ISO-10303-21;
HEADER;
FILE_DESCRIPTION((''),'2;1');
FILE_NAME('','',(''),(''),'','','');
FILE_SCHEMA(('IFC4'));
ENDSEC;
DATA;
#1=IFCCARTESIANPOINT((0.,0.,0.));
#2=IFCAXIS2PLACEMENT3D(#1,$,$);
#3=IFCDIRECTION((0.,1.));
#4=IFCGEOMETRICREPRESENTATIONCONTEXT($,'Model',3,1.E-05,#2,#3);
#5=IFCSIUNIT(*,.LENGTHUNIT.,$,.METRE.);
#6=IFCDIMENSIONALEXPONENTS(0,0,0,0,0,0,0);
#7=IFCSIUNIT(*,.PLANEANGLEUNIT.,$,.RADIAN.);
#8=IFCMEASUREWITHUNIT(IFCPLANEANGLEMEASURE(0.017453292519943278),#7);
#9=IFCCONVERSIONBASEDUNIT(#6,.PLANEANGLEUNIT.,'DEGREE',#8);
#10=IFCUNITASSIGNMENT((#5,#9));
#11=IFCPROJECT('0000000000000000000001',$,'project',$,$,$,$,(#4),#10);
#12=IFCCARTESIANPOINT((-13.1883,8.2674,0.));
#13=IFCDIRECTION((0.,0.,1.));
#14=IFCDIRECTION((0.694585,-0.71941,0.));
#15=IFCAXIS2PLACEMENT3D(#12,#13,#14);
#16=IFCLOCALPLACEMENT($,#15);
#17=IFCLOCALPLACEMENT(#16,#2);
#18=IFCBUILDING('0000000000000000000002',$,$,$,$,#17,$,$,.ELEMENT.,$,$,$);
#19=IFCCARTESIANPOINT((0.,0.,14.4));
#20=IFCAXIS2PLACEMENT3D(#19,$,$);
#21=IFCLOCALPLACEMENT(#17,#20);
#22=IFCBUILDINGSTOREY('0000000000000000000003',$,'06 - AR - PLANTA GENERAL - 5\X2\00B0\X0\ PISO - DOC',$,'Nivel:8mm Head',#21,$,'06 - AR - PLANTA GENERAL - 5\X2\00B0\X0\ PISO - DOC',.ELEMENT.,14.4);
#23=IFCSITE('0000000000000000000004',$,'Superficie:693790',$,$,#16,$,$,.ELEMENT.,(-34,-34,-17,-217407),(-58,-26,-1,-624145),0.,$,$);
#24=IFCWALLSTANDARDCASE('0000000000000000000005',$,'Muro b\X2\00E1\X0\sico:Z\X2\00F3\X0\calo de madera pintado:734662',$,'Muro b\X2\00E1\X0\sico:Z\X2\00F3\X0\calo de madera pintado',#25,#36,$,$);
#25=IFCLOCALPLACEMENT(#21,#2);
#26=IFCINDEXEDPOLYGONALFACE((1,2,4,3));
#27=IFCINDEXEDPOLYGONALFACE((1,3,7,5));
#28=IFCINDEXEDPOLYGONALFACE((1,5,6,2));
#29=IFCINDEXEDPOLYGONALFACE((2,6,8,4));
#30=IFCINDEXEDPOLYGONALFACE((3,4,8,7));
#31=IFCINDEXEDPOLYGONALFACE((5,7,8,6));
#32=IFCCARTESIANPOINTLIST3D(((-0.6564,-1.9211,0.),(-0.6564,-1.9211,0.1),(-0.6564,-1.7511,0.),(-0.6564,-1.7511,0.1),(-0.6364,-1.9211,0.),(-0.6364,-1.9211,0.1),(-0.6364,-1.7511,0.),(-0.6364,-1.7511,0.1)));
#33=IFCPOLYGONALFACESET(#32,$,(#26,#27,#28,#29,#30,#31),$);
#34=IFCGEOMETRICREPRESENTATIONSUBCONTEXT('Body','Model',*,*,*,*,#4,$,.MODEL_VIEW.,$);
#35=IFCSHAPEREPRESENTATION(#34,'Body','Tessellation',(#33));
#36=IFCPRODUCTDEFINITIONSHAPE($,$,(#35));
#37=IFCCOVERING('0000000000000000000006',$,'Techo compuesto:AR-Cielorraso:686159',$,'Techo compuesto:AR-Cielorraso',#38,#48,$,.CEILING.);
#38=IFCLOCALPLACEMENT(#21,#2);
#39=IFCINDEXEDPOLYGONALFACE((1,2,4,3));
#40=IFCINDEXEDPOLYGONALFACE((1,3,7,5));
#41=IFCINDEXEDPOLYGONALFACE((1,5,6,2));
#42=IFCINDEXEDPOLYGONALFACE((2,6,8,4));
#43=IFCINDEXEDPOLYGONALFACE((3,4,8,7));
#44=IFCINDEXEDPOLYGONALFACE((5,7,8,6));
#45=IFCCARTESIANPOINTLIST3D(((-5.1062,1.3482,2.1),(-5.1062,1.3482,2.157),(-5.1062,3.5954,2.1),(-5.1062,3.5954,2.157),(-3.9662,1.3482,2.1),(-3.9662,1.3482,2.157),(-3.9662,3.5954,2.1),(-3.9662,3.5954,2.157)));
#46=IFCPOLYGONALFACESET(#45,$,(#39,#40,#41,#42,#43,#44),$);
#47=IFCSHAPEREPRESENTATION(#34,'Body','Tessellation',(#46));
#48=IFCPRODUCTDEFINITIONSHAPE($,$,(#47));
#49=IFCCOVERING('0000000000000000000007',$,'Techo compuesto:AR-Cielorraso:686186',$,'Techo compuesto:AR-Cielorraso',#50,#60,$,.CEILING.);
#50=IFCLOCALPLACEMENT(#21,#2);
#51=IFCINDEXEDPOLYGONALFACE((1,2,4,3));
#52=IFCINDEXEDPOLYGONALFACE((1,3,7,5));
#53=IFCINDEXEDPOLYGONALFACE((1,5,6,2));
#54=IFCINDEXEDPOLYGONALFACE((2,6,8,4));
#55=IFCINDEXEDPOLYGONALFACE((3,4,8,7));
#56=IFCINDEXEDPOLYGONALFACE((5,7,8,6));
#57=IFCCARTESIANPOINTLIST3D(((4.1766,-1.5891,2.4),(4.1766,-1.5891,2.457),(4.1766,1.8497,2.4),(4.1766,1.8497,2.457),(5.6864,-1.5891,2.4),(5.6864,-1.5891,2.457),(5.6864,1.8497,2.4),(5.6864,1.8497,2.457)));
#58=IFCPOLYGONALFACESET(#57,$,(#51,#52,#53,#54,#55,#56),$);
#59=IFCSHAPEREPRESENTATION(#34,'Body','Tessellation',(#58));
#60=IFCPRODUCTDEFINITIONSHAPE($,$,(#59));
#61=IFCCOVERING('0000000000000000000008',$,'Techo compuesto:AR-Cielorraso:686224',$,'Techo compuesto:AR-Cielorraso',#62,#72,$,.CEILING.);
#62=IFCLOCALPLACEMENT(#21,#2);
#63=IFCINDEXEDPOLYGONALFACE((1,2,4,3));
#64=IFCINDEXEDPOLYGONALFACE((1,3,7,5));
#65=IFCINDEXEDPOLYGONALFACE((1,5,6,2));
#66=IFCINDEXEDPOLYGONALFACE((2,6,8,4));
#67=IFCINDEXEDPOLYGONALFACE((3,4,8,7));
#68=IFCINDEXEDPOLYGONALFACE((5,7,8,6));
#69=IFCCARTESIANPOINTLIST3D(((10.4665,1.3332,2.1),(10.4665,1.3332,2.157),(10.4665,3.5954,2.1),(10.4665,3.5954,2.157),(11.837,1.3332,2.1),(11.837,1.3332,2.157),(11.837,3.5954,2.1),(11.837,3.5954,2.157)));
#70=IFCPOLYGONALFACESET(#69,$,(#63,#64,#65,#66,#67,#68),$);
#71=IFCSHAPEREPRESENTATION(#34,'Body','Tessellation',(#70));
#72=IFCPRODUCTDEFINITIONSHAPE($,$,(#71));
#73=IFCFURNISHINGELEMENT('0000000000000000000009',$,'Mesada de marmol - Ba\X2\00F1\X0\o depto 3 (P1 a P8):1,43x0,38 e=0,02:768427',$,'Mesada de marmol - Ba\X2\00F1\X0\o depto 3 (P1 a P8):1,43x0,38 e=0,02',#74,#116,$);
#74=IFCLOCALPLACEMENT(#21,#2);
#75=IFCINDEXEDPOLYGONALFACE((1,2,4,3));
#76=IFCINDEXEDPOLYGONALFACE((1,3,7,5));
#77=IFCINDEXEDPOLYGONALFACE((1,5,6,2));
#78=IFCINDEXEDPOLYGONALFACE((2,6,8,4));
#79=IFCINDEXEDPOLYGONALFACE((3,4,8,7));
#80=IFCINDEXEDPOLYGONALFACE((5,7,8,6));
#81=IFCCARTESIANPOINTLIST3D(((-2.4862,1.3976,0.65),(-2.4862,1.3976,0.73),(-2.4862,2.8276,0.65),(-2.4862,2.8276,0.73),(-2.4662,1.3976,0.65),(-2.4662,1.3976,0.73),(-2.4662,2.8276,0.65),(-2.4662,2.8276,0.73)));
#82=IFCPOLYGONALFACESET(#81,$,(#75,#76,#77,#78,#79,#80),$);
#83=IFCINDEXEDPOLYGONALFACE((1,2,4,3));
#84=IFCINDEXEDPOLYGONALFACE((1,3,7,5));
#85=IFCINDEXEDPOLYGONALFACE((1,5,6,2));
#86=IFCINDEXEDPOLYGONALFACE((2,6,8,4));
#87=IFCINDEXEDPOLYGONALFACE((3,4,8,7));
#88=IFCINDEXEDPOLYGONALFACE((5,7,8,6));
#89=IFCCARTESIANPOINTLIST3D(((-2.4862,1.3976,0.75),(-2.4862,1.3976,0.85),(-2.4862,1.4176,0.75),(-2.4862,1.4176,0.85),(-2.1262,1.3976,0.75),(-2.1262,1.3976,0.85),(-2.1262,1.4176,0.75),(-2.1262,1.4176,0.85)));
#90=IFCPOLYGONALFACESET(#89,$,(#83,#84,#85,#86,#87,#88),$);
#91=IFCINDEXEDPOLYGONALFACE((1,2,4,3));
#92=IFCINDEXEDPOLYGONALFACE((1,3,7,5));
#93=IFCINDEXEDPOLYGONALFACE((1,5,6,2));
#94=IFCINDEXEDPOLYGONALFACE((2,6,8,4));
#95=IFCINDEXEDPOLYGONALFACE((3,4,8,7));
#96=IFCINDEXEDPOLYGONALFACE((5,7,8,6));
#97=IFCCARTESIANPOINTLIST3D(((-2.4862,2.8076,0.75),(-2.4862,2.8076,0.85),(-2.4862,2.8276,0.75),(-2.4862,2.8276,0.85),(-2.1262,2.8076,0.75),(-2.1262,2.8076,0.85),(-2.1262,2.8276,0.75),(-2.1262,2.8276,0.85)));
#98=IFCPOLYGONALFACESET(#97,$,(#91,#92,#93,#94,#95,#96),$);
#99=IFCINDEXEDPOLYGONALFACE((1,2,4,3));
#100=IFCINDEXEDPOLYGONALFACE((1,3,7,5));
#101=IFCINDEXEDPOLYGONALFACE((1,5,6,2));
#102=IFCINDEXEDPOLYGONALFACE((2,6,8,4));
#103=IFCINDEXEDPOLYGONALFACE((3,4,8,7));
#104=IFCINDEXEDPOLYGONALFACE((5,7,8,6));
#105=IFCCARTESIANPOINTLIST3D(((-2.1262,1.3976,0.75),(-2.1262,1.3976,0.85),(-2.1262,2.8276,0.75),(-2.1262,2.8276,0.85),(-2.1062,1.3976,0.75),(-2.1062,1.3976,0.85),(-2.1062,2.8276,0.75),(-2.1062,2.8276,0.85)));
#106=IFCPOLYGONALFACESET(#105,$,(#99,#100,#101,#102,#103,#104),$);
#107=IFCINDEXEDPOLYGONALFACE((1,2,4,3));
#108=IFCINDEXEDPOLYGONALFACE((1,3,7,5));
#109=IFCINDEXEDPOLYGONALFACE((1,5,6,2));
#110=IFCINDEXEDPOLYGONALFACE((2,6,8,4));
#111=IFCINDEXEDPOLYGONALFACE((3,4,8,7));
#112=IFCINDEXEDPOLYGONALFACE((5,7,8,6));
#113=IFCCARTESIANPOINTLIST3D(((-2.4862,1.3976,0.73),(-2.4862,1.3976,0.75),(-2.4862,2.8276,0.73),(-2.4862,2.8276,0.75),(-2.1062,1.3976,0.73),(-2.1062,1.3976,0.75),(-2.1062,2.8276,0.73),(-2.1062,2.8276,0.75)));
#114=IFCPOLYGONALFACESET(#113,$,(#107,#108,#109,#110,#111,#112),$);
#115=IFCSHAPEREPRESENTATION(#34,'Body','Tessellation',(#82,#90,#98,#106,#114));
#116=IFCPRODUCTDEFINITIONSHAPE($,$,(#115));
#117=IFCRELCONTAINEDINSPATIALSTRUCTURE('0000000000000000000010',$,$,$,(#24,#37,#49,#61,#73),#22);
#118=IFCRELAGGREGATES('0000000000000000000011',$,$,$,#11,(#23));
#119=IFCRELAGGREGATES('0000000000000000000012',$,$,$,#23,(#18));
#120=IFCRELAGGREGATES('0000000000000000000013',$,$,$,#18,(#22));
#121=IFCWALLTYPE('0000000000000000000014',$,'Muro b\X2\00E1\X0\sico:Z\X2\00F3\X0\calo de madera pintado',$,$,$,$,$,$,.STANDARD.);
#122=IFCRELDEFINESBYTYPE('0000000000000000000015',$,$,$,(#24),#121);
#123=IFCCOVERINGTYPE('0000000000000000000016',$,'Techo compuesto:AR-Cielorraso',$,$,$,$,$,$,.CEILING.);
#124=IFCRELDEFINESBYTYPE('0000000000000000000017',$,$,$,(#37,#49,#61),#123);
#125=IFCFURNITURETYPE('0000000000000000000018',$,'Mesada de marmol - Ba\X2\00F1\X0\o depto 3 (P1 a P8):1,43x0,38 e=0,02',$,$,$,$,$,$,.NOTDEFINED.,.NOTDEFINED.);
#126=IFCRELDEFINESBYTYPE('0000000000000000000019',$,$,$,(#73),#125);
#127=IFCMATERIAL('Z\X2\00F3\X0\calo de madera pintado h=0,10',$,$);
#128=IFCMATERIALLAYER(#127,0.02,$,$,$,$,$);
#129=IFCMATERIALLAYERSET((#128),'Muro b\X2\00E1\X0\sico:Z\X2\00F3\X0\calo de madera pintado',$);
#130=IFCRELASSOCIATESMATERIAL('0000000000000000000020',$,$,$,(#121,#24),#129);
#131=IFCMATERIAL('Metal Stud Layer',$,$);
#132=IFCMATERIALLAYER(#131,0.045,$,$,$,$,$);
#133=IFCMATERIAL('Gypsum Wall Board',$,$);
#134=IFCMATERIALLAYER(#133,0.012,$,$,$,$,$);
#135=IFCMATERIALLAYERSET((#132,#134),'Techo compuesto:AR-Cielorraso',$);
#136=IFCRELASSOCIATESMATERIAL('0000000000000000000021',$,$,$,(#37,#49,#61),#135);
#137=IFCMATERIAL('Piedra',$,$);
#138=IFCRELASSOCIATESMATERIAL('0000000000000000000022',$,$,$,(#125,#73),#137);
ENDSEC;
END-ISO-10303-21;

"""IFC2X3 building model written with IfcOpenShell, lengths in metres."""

from ifc_helpers import new_model, entity, si_unit, converted_unit, direction, frame, frame_2d, origin, origin_2d_with_axis, place, context, subcontext, project, spatial, rectangle, extrude, source, transform, mapped, material, layer, layer_set, layer_usage, type_object, type_shapes, element, save


model = new_model("IFC2X3")

# Units and contexts
model_context = context("Model", 3, precision=1e-05, world=origin(), true_north=direction((0.0, 1.0)))
body_context = subcontext(model_context, "Body", "Model", "MODEL_VIEW")
ifc_project = project(units=[si_unit("LENGTHUNIT", "METRE"), converted_unit("PLANEANGLEUNIT", "DEGREE", entity("IfcPlaneAngleMeasure", 0.017453292519943278), si_unit("PLANEANGLEUNIT", "RADIAN"), dimensions=[0, 0, 0, 0, 0, 0, 0])], contexts=[model_context])

# Site, building, storey
site_placement = place(None, frame((-13.1883, 8.2674, 0.0), z_axis=(0.0, 0.0, 1.0), x_axis=(0.694585, -0.71941, 0.0)))
site = spatial("IfcSite", under=ifc_project, at=site_placement, Name="Superficie:693790", CompositionType="ELEMENT", RefLatitude=(-34, -34, -17, -217407), RefLongitude=(-58, -26, -1, -624145), RefElevation=0.0)
building_placement = place(site_placement, origin())
building = spatial("IfcBuilding", under=site, at=building_placement, CompositionType="ELEMENT")
storey_placement = place(building_placement, frame((0.0, 0.0, 14.4)))
storey = spatial("IfcBuildingStorey", under=building, at=storey_placement, Name="06 - AR - PLANTA GENERAL - 5° PISO - DOC", ObjectType="Nivel:8mm Head", LongName="06 - AR - PLANTA GENERAL - 5° PISO - DOC", CompositionType="ELEMENT", Elevation=14.4)

# Wall
ifc_material_1 = material(Name="Zócalo de madera pintado h=0,10")
ifc_layer_1 = layer(ifc_material_1, 0.02)
ifc_layer_set_1 = layer_set([ifc_layer_1], Name="Muro básico:Zócalo de madera pintado")
wall_type_1 = type_object("IfcWallType", Name="Muro básico:Zócalo de madera pintado", PredefinedType="STANDARD", material=ifc_layer_set_1)
ifc_layer_usage_1 = layer_usage(ifc_layer_set_1, "AXIS2", "NEGATIVE", 0.01)
wall_1_placement = place(storey_placement, frame((-0.6464, -1.7511, 0.0), z_axis=(0.0, 0.0, 1.0), x_axis=(0.0, -1.0, 0.0)))
element("IfcWallStandardCase", 1, at=wall_1_placement, inside=storey, type_object=wall_type_1, material=ifc_layer_usage_1, Name="Muro básico:Zócalo de madera pintado:734662", ObjectType="Muro básico:Zócalo de madera pintado", context=body_context, shape_type="SweptSolid", body=[
    extrude(rectangle(XDim=0.17, YDim=0.02, at=frame_2d((0.085, 0.0), x_axis=(-1.0, 0.0))), origin(), (0.0, 0.0, 1.0), 0.1),
])

# Coverings
ifc_material_2 = material(Name="Metal Stud Layer")
ifc_layer_2 = layer(ifc_material_2, 0.045)
ifc_material_3 = material(Name="Gypsum Wall Board")
ifc_layer_3 = layer(ifc_material_3, 0.012)
ifc_layer_set_2 = layer_set([ifc_layer_2, ifc_layer_3], Name="Techo compuesto:AR-Cielorraso")
covering_type = type_object("IfcCoveringType", Name="Techo compuesto:AR-Cielorraso", PredefinedType="CEILING")
ifc_layer_usage_2 = layer_usage(ifc_layer_set_2, "AXIS3", "NEGATIVE", 0.057)
covering_1_placement = place(storey_placement, origin())
element("IfcCovering", 2, at=covering_1_placement, inside=storey, type_object=covering_type, material=ifc_layer_usage_2, Name="Techo compuesto:AR-Cielorraso:686159", ObjectType="Techo compuesto:AR-Cielorraso", PredefinedType="CEILING", context=body_context, shape_type="SweptSolid", body=[
    extrude(rectangle(XDim=1.14, YDim=2.2473, at=frame_2d((0.0, 0.0), x_axis=(1.0, 0.0))), frame((-4.5362, 2.4718, 2.1), z_axis=(0.0, 0.0, 1.0), x_axis=(-1.0, 0.0, 0.0)), (0.0, 0.0, 1.0), 0.057),
])
ifc_layer_usage_3 = layer_usage(ifc_layer_set_2, "AXIS3", "NEGATIVE", 0.057)
covering_2_placement = place(storey_placement, origin())
element("IfcCovering", 3, at=covering_2_placement, inside=storey, type_object=covering_type, material=ifc_layer_usage_3, Name="Techo compuesto:AR-Cielorraso:686186", ObjectType="Techo compuesto:AR-Cielorraso", PredefinedType="CEILING", context=body_context, shape_type="SweptSolid", body=[
    extrude(rectangle(XDim=1.5098, YDim=3.4387, at=frame_2d((0.0, 0.0), x_axis=(1.0, 0.0))), frame((4.9315, 0.1303, 2.4), z_axis=(0.0, 0.0, 1.0), x_axis=(-1.0, 0.0, 0.0)), (0.0, 0.0, 1.0), 0.057),
])
ifc_layer_usage_4 = layer_usage(ifc_layer_set_2, "AXIS3", "NEGATIVE", 0.057)
covering_3_placement = place(storey_placement, origin())
element("IfcCovering", 4, at=covering_3_placement, inside=storey, type_object=covering_type, material=ifc_layer_usage_4, Name="Techo compuesto:AR-Cielorraso:686224", ObjectType="Techo compuesto:AR-Cielorraso", PredefinedType="CEILING", context=body_context, shape_type="SweptSolid", body=[
    extrude(rectangle(XDim=1.3705, YDim=2.2623, at=frame_2d((0.0, 0.0), x_axis=(1.0, 0.0))), frame((11.1518, 2.4643, 2.1), z_axis=(0.0, 0.0, 1.0), x_axis=(-1.0, 0.0, 0.0)), (0.0, 0.0, 1.0), 0.057),
])

# Furnishing element
ifc_material_4 = material(Name="Piedra")
furniture_type = type_object("IfcFurnitureType", Name="Mesada de marmol - Baño depto 3 (P1 a P8):1,43x0,38 e=0,02", AssemblyPlace="NOTDEFINED", material=ifc_material_4)
shared_shape_1 = source(origin(), body_context, "Body", "SweptSolid", [
    extrude(rectangle(XDim=0.02, YDim=1.43, at=frame_2d((0.0, 0.0), x_axis=(1.0, 0.0))), frame((-0.4855, -0.37, 0.65), z_axis=(0.0, 0.0, 1.0), x_axis=(0.0, 1.0, 0.0)), (0.0, 0.0, 1.0), 0.08),
    extrude(rectangle(XDim=0.36, YDim=0.02, at=origin_2d_with_axis()), frame((0.2195, -0.2, 0.75), z_axis=(0.0, 0.0, 1.0), x_axis=(0.0, 1.0, 0.0)), (0.0, 0.0, 1.0), 0.1),
    extrude(rectangle(XDim=0.02, YDim=0.36, at=origin_2d_with_axis()), frame((-1.1905, -0.2, 0.75), z_axis=(0.0, 0.0, 1.0), x_axis=(-1.0, 0.0, 0.0)), (0.0, 0.0, 1.0), 0.1),
    extrude(rectangle(XDim=0.02, YDim=1.43, at=origin_2d_with_axis()), frame((-0.4855, -0.01, 0.75), z_axis=(0.0, 0.0, 1.0), x_axis=(0.0, -1.0, 0.0)), (0.0, 0.0, 1.0), 0.1),
    extrude(rectangle(XDim=1.43, YDim=0.38, at=origin_2d_with_axis()), frame((-0.4855, -0.19, 0.73), z_axis=(0.0, 0.0, 1.0), x_axis=(-1.0, 0.0, 0.0)), (0.0, 0.0, 1.0), 0.02),
])
type_shapes(furniture_type, [shared_shape_1])
furnishing_placement = place(storey_placement, frame((-2.1062, 1.6271, 0.0), z_axis=(0.0, 0.0, 1.0), x_axis=(0.0, -1.0, 0.0)))
element("IfcFurnishingElement", 5, at=furnishing_placement, inside=storey, type_object=furniture_type, material=ifc_material_4, Name="Mesada de marmol - Baño depto 3 (P1 a P8):1,43x0,38 e=0,02:768427", ObjectType="Mesada de marmol - Baño depto 3 (P1 a P8):1,43x0,38 e=0,02", context=body_context, shape_type="MappedRepresentation", body=[
    mapped(shared_shape_1, transform((0.0, 0.0, 0.0), scale=1.0)),
])

save(model, "model.ifc")
